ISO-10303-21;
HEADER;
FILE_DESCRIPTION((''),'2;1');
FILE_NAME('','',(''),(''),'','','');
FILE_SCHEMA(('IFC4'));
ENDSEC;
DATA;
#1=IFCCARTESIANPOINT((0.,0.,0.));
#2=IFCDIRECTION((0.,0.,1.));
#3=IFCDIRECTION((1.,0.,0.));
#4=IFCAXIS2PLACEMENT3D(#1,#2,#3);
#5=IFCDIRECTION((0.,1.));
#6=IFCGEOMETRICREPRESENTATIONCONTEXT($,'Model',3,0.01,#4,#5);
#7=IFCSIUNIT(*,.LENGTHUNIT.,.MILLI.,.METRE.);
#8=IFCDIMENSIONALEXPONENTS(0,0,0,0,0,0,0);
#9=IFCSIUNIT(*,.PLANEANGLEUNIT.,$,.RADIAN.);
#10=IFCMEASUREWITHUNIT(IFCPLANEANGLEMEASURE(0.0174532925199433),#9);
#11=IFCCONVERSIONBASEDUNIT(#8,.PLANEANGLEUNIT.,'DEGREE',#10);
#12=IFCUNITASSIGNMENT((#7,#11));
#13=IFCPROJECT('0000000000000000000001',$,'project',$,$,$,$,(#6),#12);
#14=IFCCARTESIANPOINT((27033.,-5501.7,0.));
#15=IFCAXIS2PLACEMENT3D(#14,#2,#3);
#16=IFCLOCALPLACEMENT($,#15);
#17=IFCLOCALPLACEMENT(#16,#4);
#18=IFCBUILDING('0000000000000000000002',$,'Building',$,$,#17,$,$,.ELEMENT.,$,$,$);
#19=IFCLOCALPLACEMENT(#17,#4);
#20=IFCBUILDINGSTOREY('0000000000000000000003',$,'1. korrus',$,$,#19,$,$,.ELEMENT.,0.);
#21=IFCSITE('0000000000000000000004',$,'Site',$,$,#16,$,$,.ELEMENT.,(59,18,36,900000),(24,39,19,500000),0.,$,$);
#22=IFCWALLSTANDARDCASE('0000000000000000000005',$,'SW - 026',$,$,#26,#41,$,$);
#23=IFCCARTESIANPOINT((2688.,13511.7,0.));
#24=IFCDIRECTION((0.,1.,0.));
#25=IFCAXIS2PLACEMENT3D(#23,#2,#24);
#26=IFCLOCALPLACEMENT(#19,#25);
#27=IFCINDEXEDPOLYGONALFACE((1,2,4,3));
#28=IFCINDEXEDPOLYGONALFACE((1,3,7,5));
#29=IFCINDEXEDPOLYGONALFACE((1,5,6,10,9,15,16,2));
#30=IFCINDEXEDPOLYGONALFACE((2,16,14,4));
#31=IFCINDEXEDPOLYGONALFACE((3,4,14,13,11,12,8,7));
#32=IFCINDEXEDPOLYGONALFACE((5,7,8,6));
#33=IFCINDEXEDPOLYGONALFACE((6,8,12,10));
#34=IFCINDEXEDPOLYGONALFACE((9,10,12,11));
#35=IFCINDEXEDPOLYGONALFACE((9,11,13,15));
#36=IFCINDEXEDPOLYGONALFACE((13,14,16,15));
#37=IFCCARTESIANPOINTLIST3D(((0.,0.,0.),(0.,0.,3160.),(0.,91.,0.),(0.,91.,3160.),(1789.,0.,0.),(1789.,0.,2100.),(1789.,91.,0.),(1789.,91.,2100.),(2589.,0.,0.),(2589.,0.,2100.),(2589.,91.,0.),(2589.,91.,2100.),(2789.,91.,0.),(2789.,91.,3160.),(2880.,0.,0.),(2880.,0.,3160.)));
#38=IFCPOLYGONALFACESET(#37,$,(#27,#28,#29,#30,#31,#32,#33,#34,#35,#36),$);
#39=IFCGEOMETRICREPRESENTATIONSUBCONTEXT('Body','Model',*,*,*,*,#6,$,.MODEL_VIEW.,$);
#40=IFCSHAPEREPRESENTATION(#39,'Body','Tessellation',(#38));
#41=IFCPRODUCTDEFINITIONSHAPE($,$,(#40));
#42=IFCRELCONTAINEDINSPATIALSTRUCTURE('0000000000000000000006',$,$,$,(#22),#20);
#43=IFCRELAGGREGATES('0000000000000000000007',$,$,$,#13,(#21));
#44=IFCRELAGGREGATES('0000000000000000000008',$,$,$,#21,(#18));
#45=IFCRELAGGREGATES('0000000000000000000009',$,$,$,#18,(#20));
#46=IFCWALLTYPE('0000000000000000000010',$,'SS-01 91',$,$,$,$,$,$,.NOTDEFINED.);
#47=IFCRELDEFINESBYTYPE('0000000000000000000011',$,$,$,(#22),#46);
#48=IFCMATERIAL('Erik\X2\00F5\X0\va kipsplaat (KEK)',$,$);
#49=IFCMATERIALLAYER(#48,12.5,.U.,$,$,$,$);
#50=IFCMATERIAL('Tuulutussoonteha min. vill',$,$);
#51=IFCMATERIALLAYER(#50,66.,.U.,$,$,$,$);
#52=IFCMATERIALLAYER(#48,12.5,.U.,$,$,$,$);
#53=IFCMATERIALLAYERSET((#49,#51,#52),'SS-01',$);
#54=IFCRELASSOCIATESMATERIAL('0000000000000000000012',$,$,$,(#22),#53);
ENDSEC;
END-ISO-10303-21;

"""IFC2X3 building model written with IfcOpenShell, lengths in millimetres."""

from ifc_helpers import new_model, entity, si_unit, converted_unit, direction, frame, origin_with_axes, origin_2d_with_axis, place, context, subcontext, project, spatial, polyline, rectangle, outline, extrude, material, layer, layer_set, layer_usage, type_object, element, save


model = new_model("IFC2X3")

# Units and contexts
model_context = context("Model", 3, precision=0.01, world=origin_with_axes(), true_north=direction((0.0, 1.0)))
body_context = subcontext(model_context, "Body", "Model", "MODEL_VIEW")
ifc_project = project(units=[si_unit("LENGTHUNIT", "METRE", prefix="MILLI"), converted_unit("PLANEANGLEUNIT", "DEGREE", entity("IfcPlaneAngleMeasure", 0.0174532925199433), si_unit("PLANEANGLEUNIT", "RADIAN"), dimensions=[0, 0, 0, 0, 0, 0, 0])], contexts=[model_context])

# Site, building, storey
site_placement = place(None, frame((27033.0, -5501.7, 0.0), z_axis=(0.0, 0.0, 1.0), x_axis=(1.0, 0.0, 0.0)))
site = spatial("IfcSite", under=ifc_project, at=site_placement, Name="Site", CompositionType="ELEMENT", RefLatitude=(59, 18, 36, 900000), RefLongitude=(24, 39, 19, 500000), RefElevation=0.0)
building_placement = place(site_placement, origin_with_axes())
building = spatial("IfcBuilding", under=site, at=building_placement, Name="Building", CompositionType="ELEMENT")
storey_placement = place(building_placement, origin_with_axes())
storey = spatial("IfcBuildingStorey", under=building, at=storey_placement, Name="1. korrus", CompositionType="ELEMENT", Elevation=0.0)

# Wall, opening
ifc_material_1 = material(Name="Erikõva kipsplaat (KEK)")
ifc_layer_1 = layer(ifc_material_1, 12.5, ventilated="UNKNOWN")
ifc_material_2 = material(Name="Tuulutussoonteha min. vill")
ifc_layer_2 = layer(ifc_material_2, 66.0, ventilated="UNKNOWN")
ifc_layer_3 = layer(ifc_material_1, 12.5, ventilated="UNKNOWN")
ifc_layer_set_1 = layer_set([ifc_layer_1, ifc_layer_2, ifc_layer_3], Name="SS-01")
ifc_layer_usage_1 = layer_usage(ifc_layer_set_1, "AXIS2", "NEGATIVE", 91.0)
wall_type_1 = type_object("IfcWallType", Name="SS-01 91", PredefinedType="NOTDEFINED")
wall_1_placement = place(storey_placement, frame((2688.0, 13511.7, 0.0), z_axis=(0.0, 0.0, 1.0), x_axis=(0.0, 1.0, 0.0)))
wall_1 = element("IfcWallStandardCase", 1, at=wall_1_placement, inside=storey, type_object=wall_type_1, material=ifc_layer_usage_1, Name="SW - 026", context=body_context, shape_type="SweptSolid", body=[
    extrude(outline(polyline([(0.0, 0.0), (2880.0, 0.0), (2789.0, 91.0), (0.0, 91.0), (0.0, 0.0)])), origin_with_axes(), (0.0, 0.0, 1.0), 3160.0),
])
opening_1_placement = place(wall_1_placement, frame((2189.0, 0.0, 0.0), z_axis=(0.0, 0.0, 1.0), x_axis=(1.0, 0.0, 0.0)))
element("IfcOpeningElement", 2, at=opening_1_placement, cuts=wall_1, context=body_context, shape_type="SweptSolid", body=[
    extrude(rectangle(XDim=800.0, YDim=2100.0, at=origin_2d_with_axis()), frame((0.0, 91.0, 1050.0), z_axis=(0.0, -1.0, 0.0), x_axis=(-1.0, 0.0, 0.0)), (0.0, 0.0, 1.0), 273.0),
    extrude(rectangle(XDim=874.0, YDim=2137.0, at=origin_2d_with_axis()), frame((0.0, 0.0, 1068.5), z_axis=(0.0, 1.0, 0.0), x_axis=(-1.0, 0.0, 0.0)), (0.0, 0.0, -1.0), 91.0),
])

save(model, "model.ifc")
